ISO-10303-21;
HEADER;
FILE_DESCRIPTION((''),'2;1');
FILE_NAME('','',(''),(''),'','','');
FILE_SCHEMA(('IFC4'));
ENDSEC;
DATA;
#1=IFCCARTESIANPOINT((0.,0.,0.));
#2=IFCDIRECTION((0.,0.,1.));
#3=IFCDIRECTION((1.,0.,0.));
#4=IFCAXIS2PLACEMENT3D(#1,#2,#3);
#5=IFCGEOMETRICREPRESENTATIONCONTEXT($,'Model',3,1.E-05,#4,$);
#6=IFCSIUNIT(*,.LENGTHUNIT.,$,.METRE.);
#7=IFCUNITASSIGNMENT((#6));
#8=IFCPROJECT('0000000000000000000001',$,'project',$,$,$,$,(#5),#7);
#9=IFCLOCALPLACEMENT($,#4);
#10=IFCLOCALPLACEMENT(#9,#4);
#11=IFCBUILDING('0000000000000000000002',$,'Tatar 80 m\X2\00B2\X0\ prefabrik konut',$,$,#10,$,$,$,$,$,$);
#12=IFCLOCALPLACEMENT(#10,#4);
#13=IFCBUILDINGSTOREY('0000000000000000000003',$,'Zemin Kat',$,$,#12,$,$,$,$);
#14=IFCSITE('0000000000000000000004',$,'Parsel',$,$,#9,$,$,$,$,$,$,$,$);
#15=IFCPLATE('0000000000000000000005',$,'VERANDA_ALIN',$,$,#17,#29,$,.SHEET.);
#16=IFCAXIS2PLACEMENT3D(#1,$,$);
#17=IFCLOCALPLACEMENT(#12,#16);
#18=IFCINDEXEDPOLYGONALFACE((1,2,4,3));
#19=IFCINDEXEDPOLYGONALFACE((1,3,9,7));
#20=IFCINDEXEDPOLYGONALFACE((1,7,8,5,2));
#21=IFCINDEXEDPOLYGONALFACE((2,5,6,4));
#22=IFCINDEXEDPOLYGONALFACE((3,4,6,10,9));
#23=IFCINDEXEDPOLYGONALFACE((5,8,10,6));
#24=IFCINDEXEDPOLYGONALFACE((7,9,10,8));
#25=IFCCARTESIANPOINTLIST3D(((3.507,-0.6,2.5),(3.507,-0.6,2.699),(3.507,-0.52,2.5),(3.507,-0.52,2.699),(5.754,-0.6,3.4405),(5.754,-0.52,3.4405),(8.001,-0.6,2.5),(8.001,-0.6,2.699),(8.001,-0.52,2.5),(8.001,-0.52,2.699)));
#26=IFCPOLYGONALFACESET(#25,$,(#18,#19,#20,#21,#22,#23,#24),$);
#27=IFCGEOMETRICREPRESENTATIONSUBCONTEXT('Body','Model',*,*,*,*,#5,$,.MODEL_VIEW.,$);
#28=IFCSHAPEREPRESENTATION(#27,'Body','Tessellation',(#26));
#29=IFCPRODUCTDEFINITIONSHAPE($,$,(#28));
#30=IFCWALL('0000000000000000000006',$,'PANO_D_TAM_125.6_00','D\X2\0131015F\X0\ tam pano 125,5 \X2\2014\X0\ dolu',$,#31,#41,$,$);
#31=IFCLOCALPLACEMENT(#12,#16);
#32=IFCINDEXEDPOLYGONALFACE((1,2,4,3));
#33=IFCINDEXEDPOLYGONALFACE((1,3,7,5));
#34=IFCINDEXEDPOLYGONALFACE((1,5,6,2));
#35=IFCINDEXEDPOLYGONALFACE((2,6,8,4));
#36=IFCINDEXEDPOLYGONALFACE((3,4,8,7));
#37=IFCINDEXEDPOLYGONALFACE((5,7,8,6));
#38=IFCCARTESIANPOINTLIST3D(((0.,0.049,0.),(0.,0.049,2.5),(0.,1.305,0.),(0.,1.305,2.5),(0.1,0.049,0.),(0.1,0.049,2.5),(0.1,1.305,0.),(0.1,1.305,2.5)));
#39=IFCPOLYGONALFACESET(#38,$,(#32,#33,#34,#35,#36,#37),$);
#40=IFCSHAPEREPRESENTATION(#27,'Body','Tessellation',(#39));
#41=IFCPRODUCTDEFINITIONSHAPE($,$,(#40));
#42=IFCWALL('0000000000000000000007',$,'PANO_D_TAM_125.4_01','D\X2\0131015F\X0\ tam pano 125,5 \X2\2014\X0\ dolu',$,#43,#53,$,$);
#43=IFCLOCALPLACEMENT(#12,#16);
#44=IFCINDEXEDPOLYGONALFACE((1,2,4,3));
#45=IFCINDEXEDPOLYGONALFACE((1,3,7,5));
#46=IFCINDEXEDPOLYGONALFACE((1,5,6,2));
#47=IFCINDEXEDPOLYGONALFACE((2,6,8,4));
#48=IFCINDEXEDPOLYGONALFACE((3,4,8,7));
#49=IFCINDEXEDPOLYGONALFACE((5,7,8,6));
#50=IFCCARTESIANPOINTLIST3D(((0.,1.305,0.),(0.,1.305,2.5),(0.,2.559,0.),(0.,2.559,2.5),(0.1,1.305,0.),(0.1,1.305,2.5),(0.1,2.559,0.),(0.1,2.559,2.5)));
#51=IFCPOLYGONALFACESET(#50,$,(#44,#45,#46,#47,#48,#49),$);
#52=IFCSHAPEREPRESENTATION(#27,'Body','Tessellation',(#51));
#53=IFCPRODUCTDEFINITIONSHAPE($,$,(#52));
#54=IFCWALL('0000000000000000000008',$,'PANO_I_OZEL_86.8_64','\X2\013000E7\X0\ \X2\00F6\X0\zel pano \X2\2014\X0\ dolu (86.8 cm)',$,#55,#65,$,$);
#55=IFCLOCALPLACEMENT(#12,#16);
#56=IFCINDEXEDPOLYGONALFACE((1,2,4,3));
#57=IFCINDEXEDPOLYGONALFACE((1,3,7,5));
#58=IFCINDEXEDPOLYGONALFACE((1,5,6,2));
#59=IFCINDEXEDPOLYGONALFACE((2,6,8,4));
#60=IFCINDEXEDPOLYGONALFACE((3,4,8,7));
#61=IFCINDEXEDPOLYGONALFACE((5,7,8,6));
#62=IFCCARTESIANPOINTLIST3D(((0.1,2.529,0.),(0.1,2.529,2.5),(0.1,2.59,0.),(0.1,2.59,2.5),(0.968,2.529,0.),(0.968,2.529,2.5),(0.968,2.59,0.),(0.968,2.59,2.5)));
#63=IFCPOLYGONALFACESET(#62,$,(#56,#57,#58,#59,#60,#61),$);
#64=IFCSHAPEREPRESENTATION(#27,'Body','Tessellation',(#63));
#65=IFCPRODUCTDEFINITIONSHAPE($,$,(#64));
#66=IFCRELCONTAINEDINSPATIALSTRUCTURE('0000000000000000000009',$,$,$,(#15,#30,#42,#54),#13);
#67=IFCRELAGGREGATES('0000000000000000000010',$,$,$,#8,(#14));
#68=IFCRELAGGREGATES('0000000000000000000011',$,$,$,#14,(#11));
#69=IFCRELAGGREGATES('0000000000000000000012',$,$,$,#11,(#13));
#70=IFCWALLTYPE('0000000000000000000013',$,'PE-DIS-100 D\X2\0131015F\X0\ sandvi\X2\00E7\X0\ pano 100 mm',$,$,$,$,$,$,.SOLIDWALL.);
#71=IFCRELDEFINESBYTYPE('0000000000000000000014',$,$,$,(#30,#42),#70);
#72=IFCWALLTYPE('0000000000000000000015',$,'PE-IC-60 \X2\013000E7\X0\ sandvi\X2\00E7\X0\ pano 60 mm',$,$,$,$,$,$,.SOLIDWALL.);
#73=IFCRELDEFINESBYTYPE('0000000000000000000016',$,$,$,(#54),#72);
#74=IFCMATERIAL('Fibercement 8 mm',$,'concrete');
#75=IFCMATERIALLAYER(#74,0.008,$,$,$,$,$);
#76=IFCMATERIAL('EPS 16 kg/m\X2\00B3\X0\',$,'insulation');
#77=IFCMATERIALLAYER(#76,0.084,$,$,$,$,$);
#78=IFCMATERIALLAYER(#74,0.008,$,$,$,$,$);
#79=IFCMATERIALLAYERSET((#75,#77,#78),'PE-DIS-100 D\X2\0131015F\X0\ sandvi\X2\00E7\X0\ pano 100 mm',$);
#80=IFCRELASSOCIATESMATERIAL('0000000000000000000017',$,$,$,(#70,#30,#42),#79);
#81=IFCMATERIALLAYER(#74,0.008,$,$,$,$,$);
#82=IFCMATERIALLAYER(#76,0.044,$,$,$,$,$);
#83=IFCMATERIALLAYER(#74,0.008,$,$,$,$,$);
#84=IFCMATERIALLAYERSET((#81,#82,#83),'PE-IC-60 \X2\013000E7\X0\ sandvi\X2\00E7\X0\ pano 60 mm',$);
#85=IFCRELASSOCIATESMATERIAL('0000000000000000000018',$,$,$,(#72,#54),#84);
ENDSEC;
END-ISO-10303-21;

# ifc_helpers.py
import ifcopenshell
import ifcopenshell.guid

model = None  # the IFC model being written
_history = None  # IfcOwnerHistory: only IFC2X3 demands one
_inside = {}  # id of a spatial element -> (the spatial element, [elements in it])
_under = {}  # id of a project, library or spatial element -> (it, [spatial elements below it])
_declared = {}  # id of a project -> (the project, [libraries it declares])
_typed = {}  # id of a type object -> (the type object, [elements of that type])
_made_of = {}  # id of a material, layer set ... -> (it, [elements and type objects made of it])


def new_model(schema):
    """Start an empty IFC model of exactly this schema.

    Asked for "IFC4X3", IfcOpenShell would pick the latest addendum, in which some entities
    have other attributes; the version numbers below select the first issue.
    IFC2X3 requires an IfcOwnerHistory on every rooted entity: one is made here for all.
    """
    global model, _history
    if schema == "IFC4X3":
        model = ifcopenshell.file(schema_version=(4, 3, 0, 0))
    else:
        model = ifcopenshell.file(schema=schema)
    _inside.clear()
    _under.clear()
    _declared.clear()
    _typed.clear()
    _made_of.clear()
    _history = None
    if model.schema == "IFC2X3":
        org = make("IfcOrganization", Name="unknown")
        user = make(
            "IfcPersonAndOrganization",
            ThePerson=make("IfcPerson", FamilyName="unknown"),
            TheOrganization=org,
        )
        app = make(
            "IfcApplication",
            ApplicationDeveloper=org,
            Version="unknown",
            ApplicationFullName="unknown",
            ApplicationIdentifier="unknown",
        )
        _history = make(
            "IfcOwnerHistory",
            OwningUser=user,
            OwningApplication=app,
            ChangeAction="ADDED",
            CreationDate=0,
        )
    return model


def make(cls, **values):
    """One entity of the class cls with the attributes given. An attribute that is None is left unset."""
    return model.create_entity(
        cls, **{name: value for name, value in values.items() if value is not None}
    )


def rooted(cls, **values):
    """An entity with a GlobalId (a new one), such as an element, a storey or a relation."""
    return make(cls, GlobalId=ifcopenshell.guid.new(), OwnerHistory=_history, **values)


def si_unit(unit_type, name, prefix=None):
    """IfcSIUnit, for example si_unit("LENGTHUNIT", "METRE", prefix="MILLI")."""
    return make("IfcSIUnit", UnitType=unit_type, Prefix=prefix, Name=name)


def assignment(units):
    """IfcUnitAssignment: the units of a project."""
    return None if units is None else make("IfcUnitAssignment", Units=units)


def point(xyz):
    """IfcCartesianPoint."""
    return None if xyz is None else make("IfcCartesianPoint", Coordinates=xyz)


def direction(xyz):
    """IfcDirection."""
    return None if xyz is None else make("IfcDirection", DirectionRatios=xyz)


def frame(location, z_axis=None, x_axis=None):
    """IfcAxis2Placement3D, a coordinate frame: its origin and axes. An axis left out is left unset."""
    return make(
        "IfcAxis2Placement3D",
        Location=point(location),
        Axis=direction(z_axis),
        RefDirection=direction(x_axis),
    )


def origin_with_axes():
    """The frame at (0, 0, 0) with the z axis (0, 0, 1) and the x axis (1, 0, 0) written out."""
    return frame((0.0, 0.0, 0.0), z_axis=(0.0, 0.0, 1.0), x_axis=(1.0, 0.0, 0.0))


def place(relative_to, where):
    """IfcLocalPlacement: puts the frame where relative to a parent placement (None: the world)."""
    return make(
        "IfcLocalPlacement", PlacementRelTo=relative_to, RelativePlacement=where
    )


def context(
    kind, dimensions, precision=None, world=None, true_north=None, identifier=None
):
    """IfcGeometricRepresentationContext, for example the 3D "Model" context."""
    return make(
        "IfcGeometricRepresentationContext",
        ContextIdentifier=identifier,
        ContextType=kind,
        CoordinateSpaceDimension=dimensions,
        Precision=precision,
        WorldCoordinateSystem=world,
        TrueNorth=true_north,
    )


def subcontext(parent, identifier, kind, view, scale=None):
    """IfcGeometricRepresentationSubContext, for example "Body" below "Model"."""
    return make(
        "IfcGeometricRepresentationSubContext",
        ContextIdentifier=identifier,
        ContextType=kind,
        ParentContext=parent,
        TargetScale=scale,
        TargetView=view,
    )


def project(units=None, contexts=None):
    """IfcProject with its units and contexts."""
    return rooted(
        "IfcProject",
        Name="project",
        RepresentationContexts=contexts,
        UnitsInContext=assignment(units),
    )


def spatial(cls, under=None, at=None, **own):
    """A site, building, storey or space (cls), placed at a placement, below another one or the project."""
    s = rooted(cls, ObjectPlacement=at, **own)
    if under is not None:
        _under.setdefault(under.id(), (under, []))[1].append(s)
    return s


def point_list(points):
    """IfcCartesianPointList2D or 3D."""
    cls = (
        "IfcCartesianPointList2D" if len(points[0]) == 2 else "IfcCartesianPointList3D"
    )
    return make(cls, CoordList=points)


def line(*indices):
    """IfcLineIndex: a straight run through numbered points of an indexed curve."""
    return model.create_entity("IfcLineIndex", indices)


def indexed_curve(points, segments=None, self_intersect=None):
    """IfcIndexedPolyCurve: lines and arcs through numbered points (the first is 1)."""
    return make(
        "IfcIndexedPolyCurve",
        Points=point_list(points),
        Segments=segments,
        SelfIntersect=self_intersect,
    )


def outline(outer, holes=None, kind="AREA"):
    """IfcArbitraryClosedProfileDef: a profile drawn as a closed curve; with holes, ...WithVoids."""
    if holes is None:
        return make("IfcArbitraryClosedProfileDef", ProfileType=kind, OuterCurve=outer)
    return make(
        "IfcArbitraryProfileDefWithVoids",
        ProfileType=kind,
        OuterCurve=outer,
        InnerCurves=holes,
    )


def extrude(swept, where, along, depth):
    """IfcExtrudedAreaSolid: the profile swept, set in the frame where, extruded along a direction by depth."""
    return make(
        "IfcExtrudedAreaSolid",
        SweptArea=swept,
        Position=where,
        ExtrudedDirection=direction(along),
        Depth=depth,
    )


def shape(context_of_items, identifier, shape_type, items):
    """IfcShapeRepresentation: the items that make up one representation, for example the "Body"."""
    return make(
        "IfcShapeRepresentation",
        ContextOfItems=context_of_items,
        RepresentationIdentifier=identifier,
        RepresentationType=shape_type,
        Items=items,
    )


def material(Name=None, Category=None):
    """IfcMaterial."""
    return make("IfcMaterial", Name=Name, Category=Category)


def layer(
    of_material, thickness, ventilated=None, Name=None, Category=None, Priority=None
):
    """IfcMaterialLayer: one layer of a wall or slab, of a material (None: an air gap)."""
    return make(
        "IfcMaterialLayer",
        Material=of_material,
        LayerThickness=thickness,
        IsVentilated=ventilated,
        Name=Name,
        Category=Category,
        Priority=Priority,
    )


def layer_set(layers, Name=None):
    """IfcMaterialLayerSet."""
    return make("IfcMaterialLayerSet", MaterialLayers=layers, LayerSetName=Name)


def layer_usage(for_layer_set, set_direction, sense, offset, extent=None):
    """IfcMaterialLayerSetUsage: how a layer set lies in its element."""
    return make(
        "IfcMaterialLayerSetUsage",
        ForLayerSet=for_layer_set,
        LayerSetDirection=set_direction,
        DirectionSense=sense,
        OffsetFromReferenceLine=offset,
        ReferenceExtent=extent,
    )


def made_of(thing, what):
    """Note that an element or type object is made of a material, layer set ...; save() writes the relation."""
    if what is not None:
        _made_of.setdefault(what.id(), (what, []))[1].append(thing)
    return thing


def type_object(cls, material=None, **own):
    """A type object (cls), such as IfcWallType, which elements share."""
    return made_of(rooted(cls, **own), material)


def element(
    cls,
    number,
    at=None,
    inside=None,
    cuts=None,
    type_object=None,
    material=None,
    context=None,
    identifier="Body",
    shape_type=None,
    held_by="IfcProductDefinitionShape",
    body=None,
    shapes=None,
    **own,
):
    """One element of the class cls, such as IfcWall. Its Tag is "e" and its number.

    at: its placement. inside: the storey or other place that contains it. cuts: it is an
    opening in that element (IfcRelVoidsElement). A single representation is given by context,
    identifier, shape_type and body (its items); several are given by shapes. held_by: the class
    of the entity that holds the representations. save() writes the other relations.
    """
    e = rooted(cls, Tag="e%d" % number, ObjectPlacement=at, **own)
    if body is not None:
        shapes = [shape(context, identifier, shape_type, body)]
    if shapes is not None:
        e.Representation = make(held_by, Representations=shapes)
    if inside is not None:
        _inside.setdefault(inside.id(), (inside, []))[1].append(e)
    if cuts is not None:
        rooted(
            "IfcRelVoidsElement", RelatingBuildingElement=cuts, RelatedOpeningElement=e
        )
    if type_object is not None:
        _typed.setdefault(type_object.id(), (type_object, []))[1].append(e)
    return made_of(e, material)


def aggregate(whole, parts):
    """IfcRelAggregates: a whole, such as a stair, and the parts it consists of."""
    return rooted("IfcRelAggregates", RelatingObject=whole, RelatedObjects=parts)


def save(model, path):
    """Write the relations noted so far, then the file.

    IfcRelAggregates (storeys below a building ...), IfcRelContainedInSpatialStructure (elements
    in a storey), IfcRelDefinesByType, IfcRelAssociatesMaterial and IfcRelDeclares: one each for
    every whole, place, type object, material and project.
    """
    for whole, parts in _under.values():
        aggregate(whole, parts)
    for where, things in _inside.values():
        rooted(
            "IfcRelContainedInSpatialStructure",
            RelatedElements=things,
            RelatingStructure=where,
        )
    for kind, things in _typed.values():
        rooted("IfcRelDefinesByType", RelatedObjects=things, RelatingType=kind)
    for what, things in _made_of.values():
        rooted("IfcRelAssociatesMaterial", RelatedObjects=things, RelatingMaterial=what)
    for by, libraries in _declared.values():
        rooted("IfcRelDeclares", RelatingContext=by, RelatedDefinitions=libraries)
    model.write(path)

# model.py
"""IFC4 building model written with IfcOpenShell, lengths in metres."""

from ifc_helpers import new_model, si_unit, frame, origin_with_axes, place, context, subcontext, project, spatial, line, indexed_curve, outline, extrude, material, layer, layer_set, layer_usage, type_object, element, save


model = new_model("IFC4")

# Units and contexts
model_context = context("Model", 3, precision=1e-05, world=origin_with_axes())
body_context = subcontext(model_context, "Body", "Model", "MODEL_VIEW")
ifc_project = project(units=[si_unit("LENGTHUNIT", "METRE")], contexts=[model_context])

# Site, building, storey
site_placement = place(None, origin_with_axes())
site = spatial("IfcSite", under=ifc_project, at=site_placement, Name="Parsel")
building_placement = place(site_placement, origin_with_axes())
building = spatial("IfcBuilding", under=site, at=building_placement, Name="Tatar 80 m² prefabrik konut")
storey_placement = place(building_placement, origin_with_axes())
storey = spatial("IfcBuildingStorey", under=building, at=storey_placement, Name="Zemin Kat")

# Plate
plate_placement = place(storey_placement, origin_with_axes())
element("IfcPlate", 1, at=plate_placement, inside=storey, Name="VERANDA_ALIN", PredefinedType="SHEET", context=body_context, shape_type="SweptSolid", body=[
    extrude(outline(indexed_curve([(3.507, 2.5), (8.001, 2.5), (8.001, 2.699), (5.754, 3.4405), (3.507, 2.699)], segments=[line(1, 2, 3, 4, 5, 1)])), frame((0.0, -0.52, 0.0), z_axis=(0.0, -1.0, 0.0), x_axis=(1.0, 0.0, 0.0)), (0.0, 0.0, 1.0), 0.08),
])

# Walls
ifc_material_1 = material(Name="Fibercement 8 mm", Category="concrete")
ifc_layer_1 = layer(ifc_material_1, 0.008)
ifc_material_2 = material(Name="EPS 16 kg/m³", Category="insulation")
ifc_layer_2 = layer(ifc_material_2, 0.084)
ifc_layer_3 = layer(ifc_material_1, 0.008)
ifc_layer_set_1 = layer_set([ifc_layer_1, ifc_layer_2, ifc_layer_3], Name="PE-DIS-100 Dış sandviç pano 100 mm")
ifc_layer_usage_1 = layer_usage(ifc_layer_set_1, "AXIS2", "POSITIVE", 0.0)
wall_type_1 = type_object("IfcWallType", Name="PE-DIS-100 Dış sandviç pano 100 mm", PredefinedType="SOLIDWALL", material=ifc_layer_set_1)
wall_1_placement = place(storey_placement, frame((0.1, 0.049, 0.0), z_axis=(0.0, 0.0, 1.0), x_axis=(0.0, 1.0, 0.0)))
element("IfcWall", 2, at=wall_1_placement, inside=storey, type_object=wall_type_1, material=ifc_layer_usage_1, Name="PANO_D_TAM_125.6_00", Description="Dış tam pano 125,5 — dolu", context=body_context, shape_type="SweptSolid", body=[
    extrude(outline(indexed_curve([(0.0, 0.0), (1.256, 0.0), (1.256, 0.1), (0.0, 0.1)], segments=[line(1, 2, 3, 4, 1)])), origin_with_axes(), (0.0, 0.0, 1.0), 2.5),
])
ifc_layer_usage_2 = layer_usage(ifc_layer_set_1, "AXIS2", "POSITIVE", 0.0)
wall_2_placement = place(storey_placement, frame((0.1, 1.305, 0.0), z_axis=(0.0, 0.0, 1.0), x_axis=(0.0, 1.0, 0.0)))
element("IfcWall", 3, at=wall_2_placement, inside=storey, type_object=wall_type_1, material=ifc_layer_usage_2, Name="PANO_D_TAM_125.4_01", Description="Dış tam pano 125,5 — dolu", context=body_context, shape_type="SweptSolid", body=[
    extrude(outline(indexed_curve([(0.0, 0.0), (1.254, 0.0), (1.254, 0.1), (0.0, 0.1)], segments=[line(1, 2, 3, 4, 1)])), origin_with_axes(), (0.0, 0.0, 1.0), 2.5),
])
ifc_layer_4 = layer(ifc_material_1, 0.008)
ifc_layer_5 = layer(ifc_material_2, 0.044)
ifc_layer_6 = layer(ifc_material_1, 0.008)
ifc_layer_set_2 = layer_set([ifc_layer_4, ifc_layer_5, ifc_layer_6], Name="PE-IC-60 İç sandviç pano 60 mm")
ifc_layer_usage_3 = layer_usage(ifc_layer_set_2, "AXIS2", "POSITIVE", 0.0)
wall_type_2 = type_object("IfcWallType", Name="PE-IC-60 İç sandviç pano 60 mm", PredefinedType="SOLIDWALL", material=ifc_layer_set_2)
wall_3_placement = place(storey_placement, frame((0.1, 2.529, 0.0), z_axis=(0.0, 0.0, 1.0), x_axis=(1.0, 0.0, 0.0)))
element("IfcWall", 4, at=wall_3_placement, inside=storey, type_object=wall_type_2, material=ifc_layer_usage_3, Name="PANO_I_OZEL_86.8_64", Description="İç özel pano — dolu (86.8 cm)", context=body_context, shape_type="SweptSolid", body=[
    extrude(outline(indexed_curve([(0.0, 0.0), (0.868, 0.0), (0.868, 0.061), (0.0, 0.061)], segments=[line(1, 2, 3, 4, 1)])), origin_with_axes(), (0.0, 0.0, 1.0), 2.5),
])

save(model, "model.ifc")
